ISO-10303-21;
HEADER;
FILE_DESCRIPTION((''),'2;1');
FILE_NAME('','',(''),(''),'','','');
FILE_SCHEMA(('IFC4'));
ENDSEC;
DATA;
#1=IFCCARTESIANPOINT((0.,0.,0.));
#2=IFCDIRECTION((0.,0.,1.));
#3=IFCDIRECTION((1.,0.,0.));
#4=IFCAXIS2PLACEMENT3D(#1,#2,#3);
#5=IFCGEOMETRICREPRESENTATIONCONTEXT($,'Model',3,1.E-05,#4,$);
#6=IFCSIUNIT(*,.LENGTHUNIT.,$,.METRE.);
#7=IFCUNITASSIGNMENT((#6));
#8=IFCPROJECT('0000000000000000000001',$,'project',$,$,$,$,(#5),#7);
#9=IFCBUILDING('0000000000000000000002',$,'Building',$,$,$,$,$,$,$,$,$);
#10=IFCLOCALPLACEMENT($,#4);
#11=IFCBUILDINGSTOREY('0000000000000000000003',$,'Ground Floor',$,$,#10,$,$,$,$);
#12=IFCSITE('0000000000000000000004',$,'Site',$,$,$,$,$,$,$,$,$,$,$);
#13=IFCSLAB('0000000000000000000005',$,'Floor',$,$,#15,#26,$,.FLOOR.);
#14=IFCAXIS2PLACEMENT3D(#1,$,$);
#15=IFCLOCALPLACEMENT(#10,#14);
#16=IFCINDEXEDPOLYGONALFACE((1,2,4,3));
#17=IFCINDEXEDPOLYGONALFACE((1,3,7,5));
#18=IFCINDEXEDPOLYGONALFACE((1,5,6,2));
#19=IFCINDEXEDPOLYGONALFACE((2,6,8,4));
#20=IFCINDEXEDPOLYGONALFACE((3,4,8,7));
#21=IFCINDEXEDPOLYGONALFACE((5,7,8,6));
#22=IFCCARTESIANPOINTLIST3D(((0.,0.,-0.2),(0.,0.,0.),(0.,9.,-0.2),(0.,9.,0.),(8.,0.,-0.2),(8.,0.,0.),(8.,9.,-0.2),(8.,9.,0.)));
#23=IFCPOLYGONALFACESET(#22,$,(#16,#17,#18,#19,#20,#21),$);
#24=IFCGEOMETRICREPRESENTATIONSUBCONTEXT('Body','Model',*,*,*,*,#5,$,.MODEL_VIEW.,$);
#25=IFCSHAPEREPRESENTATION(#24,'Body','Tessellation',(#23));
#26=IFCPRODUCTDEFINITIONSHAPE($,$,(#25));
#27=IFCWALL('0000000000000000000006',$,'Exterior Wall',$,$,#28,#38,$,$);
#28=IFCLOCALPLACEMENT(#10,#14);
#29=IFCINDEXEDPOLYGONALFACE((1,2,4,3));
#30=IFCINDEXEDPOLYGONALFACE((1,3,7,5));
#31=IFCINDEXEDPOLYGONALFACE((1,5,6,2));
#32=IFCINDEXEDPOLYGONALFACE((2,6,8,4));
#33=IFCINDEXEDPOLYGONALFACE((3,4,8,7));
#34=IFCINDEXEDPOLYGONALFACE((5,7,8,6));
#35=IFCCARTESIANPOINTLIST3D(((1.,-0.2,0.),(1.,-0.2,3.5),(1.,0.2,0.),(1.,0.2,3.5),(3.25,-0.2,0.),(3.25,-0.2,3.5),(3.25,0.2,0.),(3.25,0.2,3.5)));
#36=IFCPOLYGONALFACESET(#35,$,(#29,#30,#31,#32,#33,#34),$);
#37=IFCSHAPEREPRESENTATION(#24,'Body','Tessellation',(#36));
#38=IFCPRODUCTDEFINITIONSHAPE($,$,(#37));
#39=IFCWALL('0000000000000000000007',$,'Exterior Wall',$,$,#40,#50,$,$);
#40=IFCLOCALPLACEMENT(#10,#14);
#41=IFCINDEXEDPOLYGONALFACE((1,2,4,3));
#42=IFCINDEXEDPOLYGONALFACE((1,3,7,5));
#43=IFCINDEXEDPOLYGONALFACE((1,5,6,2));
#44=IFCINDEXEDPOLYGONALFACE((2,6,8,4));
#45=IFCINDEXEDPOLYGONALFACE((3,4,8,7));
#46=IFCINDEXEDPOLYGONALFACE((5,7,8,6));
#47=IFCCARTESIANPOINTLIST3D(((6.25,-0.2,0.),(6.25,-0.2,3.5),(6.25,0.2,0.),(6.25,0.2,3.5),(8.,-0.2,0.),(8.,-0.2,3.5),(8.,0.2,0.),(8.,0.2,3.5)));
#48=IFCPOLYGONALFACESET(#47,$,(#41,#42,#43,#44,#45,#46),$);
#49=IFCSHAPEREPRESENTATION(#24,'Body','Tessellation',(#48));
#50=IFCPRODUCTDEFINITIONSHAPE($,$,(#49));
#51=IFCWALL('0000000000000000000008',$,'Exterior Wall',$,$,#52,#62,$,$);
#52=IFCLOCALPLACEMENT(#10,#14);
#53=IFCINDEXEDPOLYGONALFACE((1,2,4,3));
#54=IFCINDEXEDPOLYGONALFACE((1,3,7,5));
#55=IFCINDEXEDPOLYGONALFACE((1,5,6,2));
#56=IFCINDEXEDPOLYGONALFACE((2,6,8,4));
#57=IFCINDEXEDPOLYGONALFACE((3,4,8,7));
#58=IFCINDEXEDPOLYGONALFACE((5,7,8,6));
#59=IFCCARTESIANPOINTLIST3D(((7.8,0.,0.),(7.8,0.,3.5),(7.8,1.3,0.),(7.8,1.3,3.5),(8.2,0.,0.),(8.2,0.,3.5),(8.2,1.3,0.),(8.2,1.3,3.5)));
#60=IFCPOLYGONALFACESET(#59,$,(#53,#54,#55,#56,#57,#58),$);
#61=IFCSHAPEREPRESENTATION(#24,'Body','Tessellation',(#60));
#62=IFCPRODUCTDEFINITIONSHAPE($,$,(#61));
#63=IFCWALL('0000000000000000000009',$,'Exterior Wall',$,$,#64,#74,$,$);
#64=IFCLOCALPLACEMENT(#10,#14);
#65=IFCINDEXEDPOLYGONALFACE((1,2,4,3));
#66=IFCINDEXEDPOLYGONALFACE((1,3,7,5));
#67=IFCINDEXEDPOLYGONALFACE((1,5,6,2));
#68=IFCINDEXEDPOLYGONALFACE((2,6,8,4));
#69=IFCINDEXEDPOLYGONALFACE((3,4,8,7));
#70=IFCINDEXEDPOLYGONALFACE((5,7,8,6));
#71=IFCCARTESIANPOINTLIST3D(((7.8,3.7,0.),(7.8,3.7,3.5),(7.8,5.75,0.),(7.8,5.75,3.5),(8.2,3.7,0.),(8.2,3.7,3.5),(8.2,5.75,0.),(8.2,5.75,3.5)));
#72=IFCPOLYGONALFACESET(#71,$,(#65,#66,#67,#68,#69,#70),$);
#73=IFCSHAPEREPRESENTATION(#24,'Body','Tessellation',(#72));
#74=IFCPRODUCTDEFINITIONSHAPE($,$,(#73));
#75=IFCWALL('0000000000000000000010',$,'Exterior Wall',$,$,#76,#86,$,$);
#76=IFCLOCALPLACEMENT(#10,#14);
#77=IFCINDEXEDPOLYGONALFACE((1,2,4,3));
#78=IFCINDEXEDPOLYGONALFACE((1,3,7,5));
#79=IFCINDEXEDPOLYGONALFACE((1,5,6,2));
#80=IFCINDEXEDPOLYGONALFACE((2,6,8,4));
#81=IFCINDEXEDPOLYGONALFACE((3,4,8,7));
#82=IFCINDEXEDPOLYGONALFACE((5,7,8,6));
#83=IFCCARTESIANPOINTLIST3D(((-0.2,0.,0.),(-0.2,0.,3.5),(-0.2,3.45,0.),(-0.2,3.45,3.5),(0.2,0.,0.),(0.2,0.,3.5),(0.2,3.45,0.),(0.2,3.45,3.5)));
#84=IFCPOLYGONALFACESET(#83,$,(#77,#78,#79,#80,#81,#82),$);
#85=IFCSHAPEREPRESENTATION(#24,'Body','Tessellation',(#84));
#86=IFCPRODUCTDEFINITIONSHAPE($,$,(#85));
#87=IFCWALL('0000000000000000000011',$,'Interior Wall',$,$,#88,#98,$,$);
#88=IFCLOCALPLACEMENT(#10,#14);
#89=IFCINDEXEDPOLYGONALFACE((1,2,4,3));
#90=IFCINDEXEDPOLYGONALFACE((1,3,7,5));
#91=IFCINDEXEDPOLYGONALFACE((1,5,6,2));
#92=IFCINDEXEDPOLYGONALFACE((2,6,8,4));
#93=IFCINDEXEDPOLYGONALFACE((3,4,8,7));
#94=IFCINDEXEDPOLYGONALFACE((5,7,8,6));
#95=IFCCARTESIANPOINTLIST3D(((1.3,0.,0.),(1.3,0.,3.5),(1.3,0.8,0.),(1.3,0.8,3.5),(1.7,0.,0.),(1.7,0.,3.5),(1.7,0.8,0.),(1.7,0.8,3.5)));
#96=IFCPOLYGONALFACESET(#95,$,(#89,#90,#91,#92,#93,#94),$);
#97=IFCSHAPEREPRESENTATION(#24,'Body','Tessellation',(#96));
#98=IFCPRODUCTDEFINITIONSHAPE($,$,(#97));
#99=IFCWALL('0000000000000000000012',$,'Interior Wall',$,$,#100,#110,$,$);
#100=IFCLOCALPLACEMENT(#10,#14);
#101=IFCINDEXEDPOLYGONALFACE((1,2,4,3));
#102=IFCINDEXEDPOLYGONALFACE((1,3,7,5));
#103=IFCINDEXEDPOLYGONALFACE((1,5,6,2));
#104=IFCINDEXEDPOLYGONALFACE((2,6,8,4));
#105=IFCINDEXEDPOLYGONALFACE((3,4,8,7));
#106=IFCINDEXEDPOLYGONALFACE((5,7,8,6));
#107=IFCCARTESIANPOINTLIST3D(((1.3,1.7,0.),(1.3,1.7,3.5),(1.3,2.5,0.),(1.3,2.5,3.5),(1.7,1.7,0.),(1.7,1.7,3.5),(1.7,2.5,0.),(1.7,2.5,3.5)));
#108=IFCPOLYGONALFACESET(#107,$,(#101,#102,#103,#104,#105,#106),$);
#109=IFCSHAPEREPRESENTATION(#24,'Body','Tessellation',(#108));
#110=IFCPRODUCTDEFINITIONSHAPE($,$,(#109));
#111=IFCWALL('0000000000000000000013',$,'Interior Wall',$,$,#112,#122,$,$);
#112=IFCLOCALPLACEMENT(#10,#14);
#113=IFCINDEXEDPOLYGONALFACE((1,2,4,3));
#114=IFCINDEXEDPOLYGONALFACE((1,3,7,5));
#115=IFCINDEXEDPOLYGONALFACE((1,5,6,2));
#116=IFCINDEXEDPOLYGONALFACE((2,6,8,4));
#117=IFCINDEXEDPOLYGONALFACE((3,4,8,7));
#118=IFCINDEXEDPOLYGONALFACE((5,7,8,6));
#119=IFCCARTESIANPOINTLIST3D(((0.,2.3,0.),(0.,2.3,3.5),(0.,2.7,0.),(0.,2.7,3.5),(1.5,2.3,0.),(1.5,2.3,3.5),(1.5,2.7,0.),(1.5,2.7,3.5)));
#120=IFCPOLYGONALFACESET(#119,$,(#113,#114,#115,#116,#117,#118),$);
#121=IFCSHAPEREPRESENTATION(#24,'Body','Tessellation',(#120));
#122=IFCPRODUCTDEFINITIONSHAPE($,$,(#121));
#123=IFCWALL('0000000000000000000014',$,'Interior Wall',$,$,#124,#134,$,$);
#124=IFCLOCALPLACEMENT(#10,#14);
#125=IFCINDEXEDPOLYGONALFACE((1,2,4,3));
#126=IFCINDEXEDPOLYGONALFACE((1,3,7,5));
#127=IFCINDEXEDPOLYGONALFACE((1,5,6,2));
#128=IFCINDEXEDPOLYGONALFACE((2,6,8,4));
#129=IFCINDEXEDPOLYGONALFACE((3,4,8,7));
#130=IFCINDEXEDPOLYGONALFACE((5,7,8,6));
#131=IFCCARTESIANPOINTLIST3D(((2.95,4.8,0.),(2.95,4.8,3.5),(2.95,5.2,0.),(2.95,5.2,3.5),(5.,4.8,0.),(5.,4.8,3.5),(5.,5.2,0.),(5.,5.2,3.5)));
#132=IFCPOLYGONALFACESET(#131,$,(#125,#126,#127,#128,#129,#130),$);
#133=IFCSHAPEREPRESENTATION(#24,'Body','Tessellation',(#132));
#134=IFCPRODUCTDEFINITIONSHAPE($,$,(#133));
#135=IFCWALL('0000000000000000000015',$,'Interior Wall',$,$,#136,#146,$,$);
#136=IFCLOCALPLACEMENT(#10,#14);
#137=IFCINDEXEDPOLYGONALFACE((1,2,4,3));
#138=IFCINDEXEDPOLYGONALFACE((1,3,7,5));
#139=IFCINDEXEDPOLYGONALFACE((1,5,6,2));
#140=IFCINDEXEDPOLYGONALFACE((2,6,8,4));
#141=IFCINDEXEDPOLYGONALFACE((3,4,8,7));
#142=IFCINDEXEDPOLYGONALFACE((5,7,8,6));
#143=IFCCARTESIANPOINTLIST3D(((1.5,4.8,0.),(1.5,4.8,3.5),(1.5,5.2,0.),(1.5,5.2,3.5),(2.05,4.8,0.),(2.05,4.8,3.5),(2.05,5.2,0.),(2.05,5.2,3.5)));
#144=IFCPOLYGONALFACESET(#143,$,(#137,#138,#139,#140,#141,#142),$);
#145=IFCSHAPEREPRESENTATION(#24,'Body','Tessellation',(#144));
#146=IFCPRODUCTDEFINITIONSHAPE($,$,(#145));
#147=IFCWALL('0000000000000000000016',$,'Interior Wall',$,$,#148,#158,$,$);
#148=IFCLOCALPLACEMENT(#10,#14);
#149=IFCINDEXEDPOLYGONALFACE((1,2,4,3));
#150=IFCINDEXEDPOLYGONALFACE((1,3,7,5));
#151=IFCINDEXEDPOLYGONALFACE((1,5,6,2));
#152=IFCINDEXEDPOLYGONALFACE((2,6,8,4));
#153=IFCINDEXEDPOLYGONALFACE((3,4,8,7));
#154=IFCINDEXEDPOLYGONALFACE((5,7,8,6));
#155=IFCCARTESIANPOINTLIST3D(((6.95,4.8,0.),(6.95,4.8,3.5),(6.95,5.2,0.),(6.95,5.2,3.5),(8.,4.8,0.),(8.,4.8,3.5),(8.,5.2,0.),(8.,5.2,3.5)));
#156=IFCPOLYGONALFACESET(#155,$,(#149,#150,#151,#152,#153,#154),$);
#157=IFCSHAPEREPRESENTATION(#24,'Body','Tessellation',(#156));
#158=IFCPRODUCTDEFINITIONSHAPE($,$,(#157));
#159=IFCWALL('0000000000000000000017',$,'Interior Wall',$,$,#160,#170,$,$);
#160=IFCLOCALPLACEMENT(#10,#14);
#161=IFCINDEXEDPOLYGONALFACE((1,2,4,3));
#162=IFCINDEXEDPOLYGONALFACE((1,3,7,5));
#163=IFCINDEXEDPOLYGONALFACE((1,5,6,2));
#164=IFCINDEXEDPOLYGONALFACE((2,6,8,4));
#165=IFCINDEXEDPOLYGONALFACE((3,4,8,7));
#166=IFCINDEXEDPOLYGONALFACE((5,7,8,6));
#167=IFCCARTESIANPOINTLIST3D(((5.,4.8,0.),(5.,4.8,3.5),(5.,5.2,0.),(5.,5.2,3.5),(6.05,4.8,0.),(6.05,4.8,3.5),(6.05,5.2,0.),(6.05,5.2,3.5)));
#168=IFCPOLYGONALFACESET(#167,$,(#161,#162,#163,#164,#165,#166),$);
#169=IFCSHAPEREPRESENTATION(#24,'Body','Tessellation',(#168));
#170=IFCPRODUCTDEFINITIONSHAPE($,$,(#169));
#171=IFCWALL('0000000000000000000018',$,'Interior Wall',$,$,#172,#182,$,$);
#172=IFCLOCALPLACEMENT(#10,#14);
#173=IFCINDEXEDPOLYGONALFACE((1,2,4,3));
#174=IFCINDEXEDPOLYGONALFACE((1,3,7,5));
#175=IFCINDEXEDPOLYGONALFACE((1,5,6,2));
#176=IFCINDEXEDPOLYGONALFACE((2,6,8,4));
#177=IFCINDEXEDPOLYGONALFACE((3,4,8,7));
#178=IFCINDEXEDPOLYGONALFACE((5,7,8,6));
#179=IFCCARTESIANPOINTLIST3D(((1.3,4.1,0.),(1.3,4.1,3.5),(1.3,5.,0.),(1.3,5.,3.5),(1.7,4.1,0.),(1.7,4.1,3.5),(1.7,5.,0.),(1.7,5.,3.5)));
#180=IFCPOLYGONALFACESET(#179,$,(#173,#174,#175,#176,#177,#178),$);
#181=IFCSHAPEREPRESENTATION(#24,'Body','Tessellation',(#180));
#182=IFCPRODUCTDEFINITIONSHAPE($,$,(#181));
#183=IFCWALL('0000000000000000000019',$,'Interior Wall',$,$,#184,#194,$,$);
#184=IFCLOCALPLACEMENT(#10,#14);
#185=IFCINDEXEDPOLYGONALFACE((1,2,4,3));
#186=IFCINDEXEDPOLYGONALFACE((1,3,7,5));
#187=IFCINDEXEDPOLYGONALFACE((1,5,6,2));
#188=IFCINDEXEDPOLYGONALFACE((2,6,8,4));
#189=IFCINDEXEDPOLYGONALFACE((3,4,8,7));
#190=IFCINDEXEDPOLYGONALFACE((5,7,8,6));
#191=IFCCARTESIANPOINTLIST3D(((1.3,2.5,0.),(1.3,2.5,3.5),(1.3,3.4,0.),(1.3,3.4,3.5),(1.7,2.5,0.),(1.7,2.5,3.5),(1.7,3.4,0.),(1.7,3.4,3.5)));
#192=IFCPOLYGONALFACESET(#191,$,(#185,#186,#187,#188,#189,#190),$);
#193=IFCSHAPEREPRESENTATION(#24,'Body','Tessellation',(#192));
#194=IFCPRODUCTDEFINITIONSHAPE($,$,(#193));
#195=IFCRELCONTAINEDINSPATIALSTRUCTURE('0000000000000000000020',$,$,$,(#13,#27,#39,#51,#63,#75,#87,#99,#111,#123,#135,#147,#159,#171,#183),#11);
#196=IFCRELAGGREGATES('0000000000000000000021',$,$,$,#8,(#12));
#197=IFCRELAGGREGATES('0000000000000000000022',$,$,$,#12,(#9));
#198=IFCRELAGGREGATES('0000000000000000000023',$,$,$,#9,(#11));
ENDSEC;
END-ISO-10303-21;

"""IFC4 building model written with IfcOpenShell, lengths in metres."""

from ifc_helpers import new_model, si_unit, frame, origin_with_axes, place, context, subcontext, project, spatial, indexed_curve, outline, extrude, element, save


model = new_model("IFC4")

# Units and contexts
model_context = context("Model", 3, precision=1e-05, world=origin_with_axes())
body_context = subcontext(model_context, "Body", "Model", "MODEL_VIEW")
ifc_project = project(units=[si_unit("LENGTHUNIT", "METRE")], contexts=[model_context])

# Site, building, storey
site = spatial("IfcSite", under=ifc_project, Name="Site")
building = spatial("IfcBuilding", under=site, Name="Building")
storey_placement = place(None, origin_with_axes())
storey = spatial("IfcBuildingStorey", under=building, at=storey_placement, Name="Ground Floor")

# Slab
slab_placement = place(storey_placement, frame((0.0, 0.0, -0.2), z_axis=(0.0, 0.0, 1.0), x_axis=(1.0, 0.0, 0.0)))
element("IfcSlab", 1, at=slab_placement, inside=storey, Name="Floor", PredefinedType="FLOOR", context=body_context, shape_type="SweptSolid", body=[
    extrude(outline(indexed_curve([(0.0, 0.0), (8.0, 0.0), (8.0, 9.0), (0.0, 9.0)])), None, (0.0, 0.0, 1.0), 0.2),
])

# Walls
wall_1_placement = place(storey_placement, frame((1.0, 0.0, 0.0), z_axis=(0.0, 0.0, 1.0), x_axis=(1.0, 0.0, 0.0)))
element("IfcWall", 2, at=wall_1_placement, inside=storey, Name="Exterior Wall", context=body_context, shape_type="SweptSolid", body=[
    extrude(outline(indexed_curve([(0.0, 0.0), (0.0, 0.4), (2.25, 0.4), (2.25, 0.0), (0.0, 0.0)], self_intersect=False)), frame((0.0, -0.2, 0.0), z_axis=(0.0, 0.0, 1.0), x_axis=(1.0, 0.0, 0.0)), (0.0, 0.0, 1.0), 3.5),
])
wall_2_placement = place(storey_placement, frame((6.25, 0.0, 0.0), z_axis=(0.0, 0.0, 1.0), x_axis=(1.0, 0.0, 0.0)))
element("IfcWall", 3, at=wall_2_placement, inside=storey, Name="Exterior Wall", context=body_context, shape_type="SweptSolid", body=[
    extrude(outline(indexed_curve([(0.0, 0.0), (0.0, 0.4), (1.75, 0.4), (1.75, 0.0), (0.0, 0.0)], self_intersect=False)), frame((0.0, -0.2, 0.0), z_axis=(0.0, 0.0, 1.0), x_axis=(1.0, 0.0, 0.0)), (0.0, 0.0, 1.0), 3.5),
])
wall_3_placement = place(storey_placement, frame((8.0, 0.0, 0.0), z_axis=(0.0, 0.0, 1.0), x_axis=(0.0, 1.0, 0.0)))
element("IfcWall", 4, at=wall_3_placement, inside=storey, Name="Exterior Wall", context=body_context, shape_type="SweptSolid", body=[
    extrude(outline(indexed_curve([(0.0, 0.0), (0.0, 0.4), (1.3, 0.4), (1.3, 0.0), (0.0, 0.0)], self_intersect=False)), frame((0.0, -0.2, 0.0), z_axis=(0.0, 0.0, 1.0), x_axis=(1.0, 0.0, 0.0)), (0.0, 0.0, 1.0), 3.5),
])
wall_4_placement = place(storey_placement, frame((8.0, 3.7, 0.0), z_axis=(0.0, 0.0, 1.0), x_axis=(0.0, 1.0, 0.0)))
element("IfcWall", 5, at=wall_4_placement, inside=storey, Name="Exterior Wall", context=body_context, shape_type="SweptSolid", body=[
    extrude(outline(indexed_curve([(0.0, 0.0), (0.0, 0.4), (2.05, 0.4), (2.05, 0.0), (0.0, 0.0)], self_intersect=False)), frame((0.0, -0.2, 0.0), z_axis=(0.0, 0.0, 1.0), x_axis=(1.0, 0.0, 0.0)), (0.0, 0.0, 1.0), 3.5),
])
wall_5_placement = place(storey_placement, frame((0.0, 3.45, 0.0), z_axis=(0.0, 0.0, 1.0), x_axis=(0.0, -1.0, 0.0)))
element("IfcWall", 6, at=wall_5_placement, inside=storey, Name="Exterior Wall", context=body_context, shape_type="SweptSolid", body=[
    extrude(outline(indexed_curve([(0.0, 0.0), (0.0, 0.4), (3.45, 0.4), (3.45, 0.0), (0.0, 0.0)], self_intersect=False)), frame((0.0, -0.2, 0.0), z_axis=(0.0, 0.0, 1.0), x_axis=(1.0, 0.0, 0.0)), (0.0, 0.0, 1.0), 3.5),
])
for number, where, z_axis, x_axis, name in (
    (7, (1.5, 0.0, 0.0), (0.0, 0.0, 1.0), (0.0, 1.0, 0.0), "Interior Wall"),
    (8, (1.5, 1.7, 0.0), (0.0, 0.0, 1.0), (0.0, 1.0, 0.0), "Interior Wall"),
):
    element("IfcWall", number, at=place(storey_placement, frame(where, z_axis=z_axis, x_axis=x_axis)), inside=storey, Name=name, context=body_context, shape_type="SweptSolid", body=[
        extrude(outline(indexed_curve([(0.0, 0.0), (0.0, 0.4), (0.8, 0.4), (0.8, 0.0), (0.0, 0.0)], self_intersect=False)), frame((0.0, -0.2, 0.0), z_axis=(0.0, 0.0, 1.0), x_axis=(1.0, 0.0, 0.0)), (0.0, 0.0, 1.0), 3.5),
    ])
wall_6_placement = place(storey_placement, frame((1.5, 2.5, 0.0), z_axis=(0.0, 0.0, 1.0), x_axis=(-1.0, 0.0, 0.0)))
element("IfcWall", 9, at=wall_6_placement, inside=storey, Name="Interior Wall", context=body_context, shape_type="SweptSolid", body=[
    extrude(outline(indexed_curve([(0.0, 0.0), (0.0, 0.4), (1.5, 0.4), (1.5, 0.0), (0.0, 0.0)], self_intersect=False)), frame((0.0, -0.2, 0.0), z_axis=(0.0, 0.0, 1.0), x_axis=(1.0, 0.0, 0.0)), (0.0, 0.0, 1.0), 3.5),
])
wall_7_placement = place(storey_placement, frame((5.0, 5.0, 0.0), z_axis=(0.0, 0.0, 1.0), x_axis=(-1.0, 0.0, 0.0)))
element("IfcWall", 10, at=wall_7_placement, inside=storey, Name="Interior Wall", context=body_context, shape_type="SweptSolid", body=[
    extrude(outline(indexed_curve([(0.0, 0.0), (0.0, 0.4), (2.05, 0.4), (2.05, 0.0), (0.0, 0.0)], self_intersect=False)), frame((0.0, -0.2, 0.0), z_axis=(0.0, 0.0, 1.0), x_axis=(1.0, 0.0, 0.0)), (0.0, 0.0, 1.0), 3.5),
])
wall_8_placement = place(storey_placement, frame((2.05, 5.0, 0.0), z_axis=(0.0, 0.0, 1.0), x_axis=(-1.0, 0.0, 0.0)))
element("IfcWall", 11, at=wall_8_placement, inside=storey, Name="Interior Wall", context=body_context, shape_type="SweptSolid", body=[
    extrude(outline(indexed_curve([(0.0, 0.0), (0.0, 0.4), (0.55, 0.4), (0.55, 0.0), (0.0, 0.0)], self_intersect=False)), frame((0.0, -0.2, 0.0), z_axis=(0.0, 0.0, 1.0), x_axis=(1.0, 0.0, 0.0)), (0.0, 0.0, 1.0), 3.5),
])
for number, where, z_axis, x_axis, name in (
    (12, (8.0, 5.0, 0.0), (0.0, 0.0, 1.0), (-1.0, 0.0, 0.0), "Interior Wall"),
    (13, (6.05, 5.0, 0.0), (0.0, 0.0, 1.0), (-1.0, 0.0, 0.0), "Interior Wall"),
):
    element("IfcWall", number, at=place(storey_placement, frame(where, z_axis=z_axis, x_axis=x_axis)), inside=storey, Name=name, context=body_context, shape_type="SweptSolid", body=[
        extrude(outline(indexed_curve([(0.0, 0.0), (0.0, 0.4), (1.05, 0.4), (1.05, 0.0), (0.0, 0.0)], self_intersect=False)), frame((0.0, -0.2, 0.0), z_axis=(0.0, 0.0, 1.0), x_axis=(1.0, 0.0, 0.0)), (0.0, 0.0, 1.0), 3.5),
    ])
wall_9_placement = place(storey_placement, frame((1.5, 5.0, 0.0), z_axis=(0.0, 0.0, 1.0), x_axis=(0.0, -1.0, 0.0)))
element("IfcWall", 14, at=wall_9_placement, inside=storey, Name="Interior Wall", context=body_context, shape_type="SweptSolid", body=[
    extrude(outline(indexed_curve([(0.0, 0.0), (0.0, 0.4), (0.9, 0.4), (0.9, 0.0), (0.0, 0.0)], self_intersect=False)), frame((0.0, -0.2, 0.0), z_axis=(0.0, 0.0, 1.0), x_axis=(1.0, 0.0, 0.0)), (0.0, 0.0, 1.0), 3.5),
])
wall_10_placement = place(storey_placement, frame((1.5, 3.4, 0.0), z_axis=(0.0, 0.0, 1.0), x_axis=(0.0, -1.0, 0.0)))
element("IfcWall", 15, at=wall_10_placement, inside=storey, Name="Interior Wall", context=body_context, shape_type="SweptSolid", body=[
    extrude(outline(indexed_curve([(0.0, 0.0), (0.0, 0.4), (0.9, 0.4), (0.9, 0.0), (0.0, 0.0)], self_intersect=False)), frame((0.0, -0.2, 0.0), z_axis=(0.0, 0.0, 1.0), x_axis=(1.0, 0.0, 0.0)), (0.0, 0.0, 1.0), 3.5),
])

save(model, "model.ifc")
